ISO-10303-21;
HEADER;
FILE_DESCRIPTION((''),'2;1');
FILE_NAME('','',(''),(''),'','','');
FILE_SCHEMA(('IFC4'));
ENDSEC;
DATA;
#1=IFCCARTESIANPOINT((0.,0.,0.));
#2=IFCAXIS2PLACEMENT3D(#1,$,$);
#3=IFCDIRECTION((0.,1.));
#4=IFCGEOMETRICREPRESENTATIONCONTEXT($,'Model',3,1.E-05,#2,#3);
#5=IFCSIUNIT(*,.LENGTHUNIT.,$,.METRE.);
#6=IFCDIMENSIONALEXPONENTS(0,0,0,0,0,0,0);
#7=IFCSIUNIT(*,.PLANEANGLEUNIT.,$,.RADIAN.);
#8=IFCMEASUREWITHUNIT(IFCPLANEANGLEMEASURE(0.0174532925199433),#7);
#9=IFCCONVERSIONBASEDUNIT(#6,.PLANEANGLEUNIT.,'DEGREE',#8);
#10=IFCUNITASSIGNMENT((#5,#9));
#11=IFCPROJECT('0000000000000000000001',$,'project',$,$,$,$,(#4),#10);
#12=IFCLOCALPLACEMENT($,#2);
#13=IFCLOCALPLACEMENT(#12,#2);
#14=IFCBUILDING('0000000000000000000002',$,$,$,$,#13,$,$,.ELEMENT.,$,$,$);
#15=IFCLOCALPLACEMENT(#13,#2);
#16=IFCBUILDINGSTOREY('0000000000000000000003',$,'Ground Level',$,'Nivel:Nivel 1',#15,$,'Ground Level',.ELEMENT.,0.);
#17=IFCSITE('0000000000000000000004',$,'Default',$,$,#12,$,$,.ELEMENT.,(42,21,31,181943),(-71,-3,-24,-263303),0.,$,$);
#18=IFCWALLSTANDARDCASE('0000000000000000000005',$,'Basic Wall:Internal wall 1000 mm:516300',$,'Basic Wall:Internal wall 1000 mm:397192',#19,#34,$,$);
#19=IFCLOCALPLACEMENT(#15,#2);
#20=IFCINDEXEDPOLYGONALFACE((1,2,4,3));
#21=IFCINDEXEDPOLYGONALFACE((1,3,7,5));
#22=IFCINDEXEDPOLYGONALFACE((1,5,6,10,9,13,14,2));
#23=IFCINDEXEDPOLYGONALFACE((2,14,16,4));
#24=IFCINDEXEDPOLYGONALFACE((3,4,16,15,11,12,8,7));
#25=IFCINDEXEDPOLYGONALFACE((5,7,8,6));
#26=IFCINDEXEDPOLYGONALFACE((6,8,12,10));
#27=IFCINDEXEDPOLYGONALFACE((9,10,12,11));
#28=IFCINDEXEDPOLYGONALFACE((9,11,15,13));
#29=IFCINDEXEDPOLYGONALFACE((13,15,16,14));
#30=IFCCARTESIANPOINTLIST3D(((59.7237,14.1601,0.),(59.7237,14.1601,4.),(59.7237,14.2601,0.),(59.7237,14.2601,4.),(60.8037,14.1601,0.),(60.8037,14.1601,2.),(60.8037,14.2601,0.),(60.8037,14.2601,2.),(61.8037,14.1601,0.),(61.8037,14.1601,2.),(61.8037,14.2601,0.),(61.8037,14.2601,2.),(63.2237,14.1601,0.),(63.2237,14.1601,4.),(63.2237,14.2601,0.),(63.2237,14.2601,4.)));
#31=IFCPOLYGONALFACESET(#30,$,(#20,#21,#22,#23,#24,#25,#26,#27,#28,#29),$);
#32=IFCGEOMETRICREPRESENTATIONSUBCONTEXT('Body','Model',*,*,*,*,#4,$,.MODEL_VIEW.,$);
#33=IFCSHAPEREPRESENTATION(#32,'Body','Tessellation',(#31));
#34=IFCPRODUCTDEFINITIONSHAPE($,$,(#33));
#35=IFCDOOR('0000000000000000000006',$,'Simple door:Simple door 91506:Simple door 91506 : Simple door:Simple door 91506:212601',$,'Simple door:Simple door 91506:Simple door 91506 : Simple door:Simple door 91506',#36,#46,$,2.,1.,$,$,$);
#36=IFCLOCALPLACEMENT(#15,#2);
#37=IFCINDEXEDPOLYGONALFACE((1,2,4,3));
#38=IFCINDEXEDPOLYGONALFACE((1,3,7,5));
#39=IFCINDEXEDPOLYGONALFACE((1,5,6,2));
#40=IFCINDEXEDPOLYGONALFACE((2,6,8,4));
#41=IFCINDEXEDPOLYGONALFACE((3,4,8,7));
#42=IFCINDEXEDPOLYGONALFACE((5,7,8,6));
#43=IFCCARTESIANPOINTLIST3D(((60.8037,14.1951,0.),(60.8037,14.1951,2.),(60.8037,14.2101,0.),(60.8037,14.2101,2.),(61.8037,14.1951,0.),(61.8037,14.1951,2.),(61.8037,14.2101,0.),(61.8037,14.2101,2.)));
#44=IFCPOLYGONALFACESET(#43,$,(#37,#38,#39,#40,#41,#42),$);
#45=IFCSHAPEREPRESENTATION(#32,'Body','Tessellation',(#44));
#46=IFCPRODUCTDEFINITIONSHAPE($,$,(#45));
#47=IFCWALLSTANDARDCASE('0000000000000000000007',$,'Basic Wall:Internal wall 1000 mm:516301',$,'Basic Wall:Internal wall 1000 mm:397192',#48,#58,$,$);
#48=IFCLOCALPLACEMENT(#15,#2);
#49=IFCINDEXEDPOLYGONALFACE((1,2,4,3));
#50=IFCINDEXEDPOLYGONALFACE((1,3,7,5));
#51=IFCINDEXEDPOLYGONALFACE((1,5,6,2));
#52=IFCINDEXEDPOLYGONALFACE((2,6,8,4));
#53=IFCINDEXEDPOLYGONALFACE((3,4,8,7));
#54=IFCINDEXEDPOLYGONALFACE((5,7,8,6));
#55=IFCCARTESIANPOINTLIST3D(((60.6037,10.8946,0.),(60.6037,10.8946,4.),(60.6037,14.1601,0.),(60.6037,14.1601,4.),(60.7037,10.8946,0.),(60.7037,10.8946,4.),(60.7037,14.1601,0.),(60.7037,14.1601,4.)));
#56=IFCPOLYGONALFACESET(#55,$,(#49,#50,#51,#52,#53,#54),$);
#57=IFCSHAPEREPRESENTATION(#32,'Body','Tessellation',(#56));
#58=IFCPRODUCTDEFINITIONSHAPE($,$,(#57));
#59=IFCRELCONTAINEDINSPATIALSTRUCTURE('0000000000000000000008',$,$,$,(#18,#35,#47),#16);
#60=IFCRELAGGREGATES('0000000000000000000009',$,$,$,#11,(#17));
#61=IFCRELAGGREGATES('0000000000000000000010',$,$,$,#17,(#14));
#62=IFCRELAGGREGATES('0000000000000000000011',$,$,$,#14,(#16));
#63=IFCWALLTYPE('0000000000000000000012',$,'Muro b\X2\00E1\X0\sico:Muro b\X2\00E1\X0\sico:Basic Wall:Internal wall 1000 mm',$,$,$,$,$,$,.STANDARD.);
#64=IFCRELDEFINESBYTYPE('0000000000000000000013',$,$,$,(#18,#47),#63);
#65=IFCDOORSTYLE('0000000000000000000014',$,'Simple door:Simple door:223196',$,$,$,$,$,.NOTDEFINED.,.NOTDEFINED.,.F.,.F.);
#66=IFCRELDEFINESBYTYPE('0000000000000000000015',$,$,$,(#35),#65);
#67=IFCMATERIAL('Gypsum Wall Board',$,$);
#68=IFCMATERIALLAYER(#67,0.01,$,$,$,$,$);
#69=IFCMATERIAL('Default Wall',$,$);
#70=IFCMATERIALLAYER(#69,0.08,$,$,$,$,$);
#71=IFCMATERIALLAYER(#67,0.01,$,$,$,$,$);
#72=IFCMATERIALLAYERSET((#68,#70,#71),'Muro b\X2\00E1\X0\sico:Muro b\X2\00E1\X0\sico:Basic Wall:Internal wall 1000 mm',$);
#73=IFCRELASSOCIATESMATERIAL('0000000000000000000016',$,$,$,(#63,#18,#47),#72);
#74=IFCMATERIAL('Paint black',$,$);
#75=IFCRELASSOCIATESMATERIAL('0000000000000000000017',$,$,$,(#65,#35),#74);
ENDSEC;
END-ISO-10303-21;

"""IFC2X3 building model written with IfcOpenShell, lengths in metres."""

from ifc_helpers import new_model, entity, si_unit, converted_unit, direction, frame, frame_2d, origin, origin_2d_with_axis, place, context, subcontext, project, spatial, rectangle, extrude, source, transform, mapped, material, layer, layer_set, layer_usage, type_object, type_shapes, element, fill, save


model = new_model("IFC2X3")

# Units and contexts
model_context = context("Model", 3, precision=1e-05, world=origin(), true_north=direction((0.0, 1.0)))
body_context = subcontext(model_context, "Body", "Model", "MODEL_VIEW")
ifc_project = project(units=[si_unit("LENGTHUNIT", "METRE"), converted_unit("PLANEANGLEUNIT", "DEGREE", entity("IfcPlaneAngleMeasure", 0.0174532925199433), si_unit("PLANEANGLEUNIT", "RADIAN"), dimensions=[0, 0, 0, 0, 0, 0, 0])], contexts=[model_context])

# Site, building, storey
site_placement = place(None, origin())
site = spatial("IfcSite", under=ifc_project, at=site_placement, Name="Default", CompositionType="ELEMENT", RefLatitude=(42, 21, 31, 181943), RefLongitude=(-71, -3, -24, -263303), RefElevation=0.0)
building_placement = place(site_placement, origin())
building = spatial("IfcBuilding", under=site, at=building_placement, CompositionType="ELEMENT")
storey_placement = place(building_placement, origin())
storey = spatial("IfcBuildingStorey", under=building, at=storey_placement, Name="Ground Level", ObjectType="Nivel:Nivel 1", LongName="Ground Level", CompositionType="ELEMENT", Elevation=0.0)

# Shared definitions
ifc_material_1 = material(Name="Gypsum Wall Board")
ifc_layer_1 = layer(ifc_material_1, 0.01)
ifc_material_2 = material(Name="Default Wall")
ifc_layer_2 = layer(ifc_material_2, 0.08)
ifc_layer_3 = layer(ifc_material_1, 0.01)
ifc_layer_set = layer_set([ifc_layer_1, ifc_layer_2, ifc_layer_3], Name="Muro básico:Muro básico:Basic Wall:Internal wall 1000 mm")
wall_type = type_object("IfcWallType", Name="Muro básico:Muro básico:Basic Wall:Internal wall 1000 mm", PredefinedType="STANDARD", material=ifc_layer_set)

# Shared definitions
ifc_material_3 = material(Name="Paint black")
door_style_1 = type_object("IfcDoorStyle", Name="Simple door:Simple door:223196", ConstructionType="NOTDEFINED", OperationType="NOTDEFINED", ParameterTakesPrecedence=False, Sizeable=False, material=ifc_material_3)
shared_shape_1 = source(origin(), body_context, "Body", "SweptSolid", [
    extrude(rectangle(XDim=1.0, YDim=0.015, at=origin_2d_with_axis()), frame((0.5, 0.0445, 0.0)), (0.0, 0.0, 1.0), 2.0),
])
type_shapes(door_style_1, [shared_shape_1])

# Wall, opening, door
ifc_layer_usage_1 = layer_usage(ifc_layer_set, "AXIS2", "NEGATIVE", 0.05)
wall_1_placement = place(storey_placement, frame((63.2237, 14.2101, 0.0), z_axis=(0.0, 0.0, 1.0), x_axis=(-1.0, 0.0, 0.0)))
wall_1 = element("IfcWallStandardCase", 1, at=wall_1_placement, inside=storey, type_object=wall_type, material=ifc_layer_usage_1, Name="Basic Wall:Internal wall 1000 mm:516300", ObjectType="Basic Wall:Internal wall 1000 mm:397192", context=body_context, shape_type="SweptSolid", body=[
    extrude(rectangle(XDim=3.5, YDim=0.1, at=frame_2d((1.75, 0.0), x_axis=(-1.0, 0.0))), origin(), (0.0, 0.0, 1.0), 4.0),
])
opening_1_placement = place(wall_1_placement, frame((63.2237, 14.2101, 0.0), z_axis=(0.0, 0.0, 1.0), x_axis=(-1.0, 0.0, 0.0)))
opening_1 = element("IfcOpeningElement", 2, at=opening_1_placement, cuts=wall_1, ObjectType="Opening", context=body_context, shape_type="SweptSolid", body=[
    extrude(rectangle(XDim=2.0, YDim=1.0, at=frame_2d((0.0, 0.0), x_axis=(0.0, 1.0))), frame((61.3037, 14.2622, 1.0), z_axis=(0.0, -1.0, 0.0), x_axis=(1.0, 0.0, 0.0)), (0.0, 0.0, 1.0), 0.104),
])
door_1_placement = place(opening_1_placement, frame((60.8037, 14.1581, 0.0)))
door_1 = element("IfcDoor", 3, at=door_1_placement, inside=storey, type_object=door_style_1, material=ifc_material_3, Name="Simple door:Simple door 91506:Simple door 91506 : Simple door:Simple door 91506:212601", ObjectType="Simple door:Simple door 91506:Simple door 91506 : Simple door:Simple door 91506", OverallHeight=2.0, OverallWidth=1.0, context=body_context, shape_type="MappedRepresentation", body=[
    mapped(shared_shape_1, transform((0.0, 0.0, 0.0), scale=1.0)),
])
fill(opening_1, door_1)

# Wall
ifc_layer_usage_2 = layer_usage(ifc_layer_set, "AXIS2", "NEGATIVE", 0.05)
wall_2_placement = place(storey_placement, frame((60.6537, 14.1601, 0.0), z_axis=(0.0, 0.0, 1.0), x_axis=(0.0, -1.0, 0.0)))
element("IfcWallStandardCase", 4, at=wall_2_placement, inside=storey, type_object=wall_type, material=ifc_layer_usage_2, Name="Basic Wall:Internal wall 1000 mm:516301", ObjectType="Basic Wall:Internal wall 1000 mm:397192", context=body_context, shape_type="SweptSolid", body=[
    extrude(rectangle(XDim=3.2655, YDim=0.1, at=frame_2d((1.6327, 0.0), x_axis=(-1.0, 0.0))), origin(), (0.0, 0.0, 1.0), 4.0),
])

save(model, "model.ifc")
